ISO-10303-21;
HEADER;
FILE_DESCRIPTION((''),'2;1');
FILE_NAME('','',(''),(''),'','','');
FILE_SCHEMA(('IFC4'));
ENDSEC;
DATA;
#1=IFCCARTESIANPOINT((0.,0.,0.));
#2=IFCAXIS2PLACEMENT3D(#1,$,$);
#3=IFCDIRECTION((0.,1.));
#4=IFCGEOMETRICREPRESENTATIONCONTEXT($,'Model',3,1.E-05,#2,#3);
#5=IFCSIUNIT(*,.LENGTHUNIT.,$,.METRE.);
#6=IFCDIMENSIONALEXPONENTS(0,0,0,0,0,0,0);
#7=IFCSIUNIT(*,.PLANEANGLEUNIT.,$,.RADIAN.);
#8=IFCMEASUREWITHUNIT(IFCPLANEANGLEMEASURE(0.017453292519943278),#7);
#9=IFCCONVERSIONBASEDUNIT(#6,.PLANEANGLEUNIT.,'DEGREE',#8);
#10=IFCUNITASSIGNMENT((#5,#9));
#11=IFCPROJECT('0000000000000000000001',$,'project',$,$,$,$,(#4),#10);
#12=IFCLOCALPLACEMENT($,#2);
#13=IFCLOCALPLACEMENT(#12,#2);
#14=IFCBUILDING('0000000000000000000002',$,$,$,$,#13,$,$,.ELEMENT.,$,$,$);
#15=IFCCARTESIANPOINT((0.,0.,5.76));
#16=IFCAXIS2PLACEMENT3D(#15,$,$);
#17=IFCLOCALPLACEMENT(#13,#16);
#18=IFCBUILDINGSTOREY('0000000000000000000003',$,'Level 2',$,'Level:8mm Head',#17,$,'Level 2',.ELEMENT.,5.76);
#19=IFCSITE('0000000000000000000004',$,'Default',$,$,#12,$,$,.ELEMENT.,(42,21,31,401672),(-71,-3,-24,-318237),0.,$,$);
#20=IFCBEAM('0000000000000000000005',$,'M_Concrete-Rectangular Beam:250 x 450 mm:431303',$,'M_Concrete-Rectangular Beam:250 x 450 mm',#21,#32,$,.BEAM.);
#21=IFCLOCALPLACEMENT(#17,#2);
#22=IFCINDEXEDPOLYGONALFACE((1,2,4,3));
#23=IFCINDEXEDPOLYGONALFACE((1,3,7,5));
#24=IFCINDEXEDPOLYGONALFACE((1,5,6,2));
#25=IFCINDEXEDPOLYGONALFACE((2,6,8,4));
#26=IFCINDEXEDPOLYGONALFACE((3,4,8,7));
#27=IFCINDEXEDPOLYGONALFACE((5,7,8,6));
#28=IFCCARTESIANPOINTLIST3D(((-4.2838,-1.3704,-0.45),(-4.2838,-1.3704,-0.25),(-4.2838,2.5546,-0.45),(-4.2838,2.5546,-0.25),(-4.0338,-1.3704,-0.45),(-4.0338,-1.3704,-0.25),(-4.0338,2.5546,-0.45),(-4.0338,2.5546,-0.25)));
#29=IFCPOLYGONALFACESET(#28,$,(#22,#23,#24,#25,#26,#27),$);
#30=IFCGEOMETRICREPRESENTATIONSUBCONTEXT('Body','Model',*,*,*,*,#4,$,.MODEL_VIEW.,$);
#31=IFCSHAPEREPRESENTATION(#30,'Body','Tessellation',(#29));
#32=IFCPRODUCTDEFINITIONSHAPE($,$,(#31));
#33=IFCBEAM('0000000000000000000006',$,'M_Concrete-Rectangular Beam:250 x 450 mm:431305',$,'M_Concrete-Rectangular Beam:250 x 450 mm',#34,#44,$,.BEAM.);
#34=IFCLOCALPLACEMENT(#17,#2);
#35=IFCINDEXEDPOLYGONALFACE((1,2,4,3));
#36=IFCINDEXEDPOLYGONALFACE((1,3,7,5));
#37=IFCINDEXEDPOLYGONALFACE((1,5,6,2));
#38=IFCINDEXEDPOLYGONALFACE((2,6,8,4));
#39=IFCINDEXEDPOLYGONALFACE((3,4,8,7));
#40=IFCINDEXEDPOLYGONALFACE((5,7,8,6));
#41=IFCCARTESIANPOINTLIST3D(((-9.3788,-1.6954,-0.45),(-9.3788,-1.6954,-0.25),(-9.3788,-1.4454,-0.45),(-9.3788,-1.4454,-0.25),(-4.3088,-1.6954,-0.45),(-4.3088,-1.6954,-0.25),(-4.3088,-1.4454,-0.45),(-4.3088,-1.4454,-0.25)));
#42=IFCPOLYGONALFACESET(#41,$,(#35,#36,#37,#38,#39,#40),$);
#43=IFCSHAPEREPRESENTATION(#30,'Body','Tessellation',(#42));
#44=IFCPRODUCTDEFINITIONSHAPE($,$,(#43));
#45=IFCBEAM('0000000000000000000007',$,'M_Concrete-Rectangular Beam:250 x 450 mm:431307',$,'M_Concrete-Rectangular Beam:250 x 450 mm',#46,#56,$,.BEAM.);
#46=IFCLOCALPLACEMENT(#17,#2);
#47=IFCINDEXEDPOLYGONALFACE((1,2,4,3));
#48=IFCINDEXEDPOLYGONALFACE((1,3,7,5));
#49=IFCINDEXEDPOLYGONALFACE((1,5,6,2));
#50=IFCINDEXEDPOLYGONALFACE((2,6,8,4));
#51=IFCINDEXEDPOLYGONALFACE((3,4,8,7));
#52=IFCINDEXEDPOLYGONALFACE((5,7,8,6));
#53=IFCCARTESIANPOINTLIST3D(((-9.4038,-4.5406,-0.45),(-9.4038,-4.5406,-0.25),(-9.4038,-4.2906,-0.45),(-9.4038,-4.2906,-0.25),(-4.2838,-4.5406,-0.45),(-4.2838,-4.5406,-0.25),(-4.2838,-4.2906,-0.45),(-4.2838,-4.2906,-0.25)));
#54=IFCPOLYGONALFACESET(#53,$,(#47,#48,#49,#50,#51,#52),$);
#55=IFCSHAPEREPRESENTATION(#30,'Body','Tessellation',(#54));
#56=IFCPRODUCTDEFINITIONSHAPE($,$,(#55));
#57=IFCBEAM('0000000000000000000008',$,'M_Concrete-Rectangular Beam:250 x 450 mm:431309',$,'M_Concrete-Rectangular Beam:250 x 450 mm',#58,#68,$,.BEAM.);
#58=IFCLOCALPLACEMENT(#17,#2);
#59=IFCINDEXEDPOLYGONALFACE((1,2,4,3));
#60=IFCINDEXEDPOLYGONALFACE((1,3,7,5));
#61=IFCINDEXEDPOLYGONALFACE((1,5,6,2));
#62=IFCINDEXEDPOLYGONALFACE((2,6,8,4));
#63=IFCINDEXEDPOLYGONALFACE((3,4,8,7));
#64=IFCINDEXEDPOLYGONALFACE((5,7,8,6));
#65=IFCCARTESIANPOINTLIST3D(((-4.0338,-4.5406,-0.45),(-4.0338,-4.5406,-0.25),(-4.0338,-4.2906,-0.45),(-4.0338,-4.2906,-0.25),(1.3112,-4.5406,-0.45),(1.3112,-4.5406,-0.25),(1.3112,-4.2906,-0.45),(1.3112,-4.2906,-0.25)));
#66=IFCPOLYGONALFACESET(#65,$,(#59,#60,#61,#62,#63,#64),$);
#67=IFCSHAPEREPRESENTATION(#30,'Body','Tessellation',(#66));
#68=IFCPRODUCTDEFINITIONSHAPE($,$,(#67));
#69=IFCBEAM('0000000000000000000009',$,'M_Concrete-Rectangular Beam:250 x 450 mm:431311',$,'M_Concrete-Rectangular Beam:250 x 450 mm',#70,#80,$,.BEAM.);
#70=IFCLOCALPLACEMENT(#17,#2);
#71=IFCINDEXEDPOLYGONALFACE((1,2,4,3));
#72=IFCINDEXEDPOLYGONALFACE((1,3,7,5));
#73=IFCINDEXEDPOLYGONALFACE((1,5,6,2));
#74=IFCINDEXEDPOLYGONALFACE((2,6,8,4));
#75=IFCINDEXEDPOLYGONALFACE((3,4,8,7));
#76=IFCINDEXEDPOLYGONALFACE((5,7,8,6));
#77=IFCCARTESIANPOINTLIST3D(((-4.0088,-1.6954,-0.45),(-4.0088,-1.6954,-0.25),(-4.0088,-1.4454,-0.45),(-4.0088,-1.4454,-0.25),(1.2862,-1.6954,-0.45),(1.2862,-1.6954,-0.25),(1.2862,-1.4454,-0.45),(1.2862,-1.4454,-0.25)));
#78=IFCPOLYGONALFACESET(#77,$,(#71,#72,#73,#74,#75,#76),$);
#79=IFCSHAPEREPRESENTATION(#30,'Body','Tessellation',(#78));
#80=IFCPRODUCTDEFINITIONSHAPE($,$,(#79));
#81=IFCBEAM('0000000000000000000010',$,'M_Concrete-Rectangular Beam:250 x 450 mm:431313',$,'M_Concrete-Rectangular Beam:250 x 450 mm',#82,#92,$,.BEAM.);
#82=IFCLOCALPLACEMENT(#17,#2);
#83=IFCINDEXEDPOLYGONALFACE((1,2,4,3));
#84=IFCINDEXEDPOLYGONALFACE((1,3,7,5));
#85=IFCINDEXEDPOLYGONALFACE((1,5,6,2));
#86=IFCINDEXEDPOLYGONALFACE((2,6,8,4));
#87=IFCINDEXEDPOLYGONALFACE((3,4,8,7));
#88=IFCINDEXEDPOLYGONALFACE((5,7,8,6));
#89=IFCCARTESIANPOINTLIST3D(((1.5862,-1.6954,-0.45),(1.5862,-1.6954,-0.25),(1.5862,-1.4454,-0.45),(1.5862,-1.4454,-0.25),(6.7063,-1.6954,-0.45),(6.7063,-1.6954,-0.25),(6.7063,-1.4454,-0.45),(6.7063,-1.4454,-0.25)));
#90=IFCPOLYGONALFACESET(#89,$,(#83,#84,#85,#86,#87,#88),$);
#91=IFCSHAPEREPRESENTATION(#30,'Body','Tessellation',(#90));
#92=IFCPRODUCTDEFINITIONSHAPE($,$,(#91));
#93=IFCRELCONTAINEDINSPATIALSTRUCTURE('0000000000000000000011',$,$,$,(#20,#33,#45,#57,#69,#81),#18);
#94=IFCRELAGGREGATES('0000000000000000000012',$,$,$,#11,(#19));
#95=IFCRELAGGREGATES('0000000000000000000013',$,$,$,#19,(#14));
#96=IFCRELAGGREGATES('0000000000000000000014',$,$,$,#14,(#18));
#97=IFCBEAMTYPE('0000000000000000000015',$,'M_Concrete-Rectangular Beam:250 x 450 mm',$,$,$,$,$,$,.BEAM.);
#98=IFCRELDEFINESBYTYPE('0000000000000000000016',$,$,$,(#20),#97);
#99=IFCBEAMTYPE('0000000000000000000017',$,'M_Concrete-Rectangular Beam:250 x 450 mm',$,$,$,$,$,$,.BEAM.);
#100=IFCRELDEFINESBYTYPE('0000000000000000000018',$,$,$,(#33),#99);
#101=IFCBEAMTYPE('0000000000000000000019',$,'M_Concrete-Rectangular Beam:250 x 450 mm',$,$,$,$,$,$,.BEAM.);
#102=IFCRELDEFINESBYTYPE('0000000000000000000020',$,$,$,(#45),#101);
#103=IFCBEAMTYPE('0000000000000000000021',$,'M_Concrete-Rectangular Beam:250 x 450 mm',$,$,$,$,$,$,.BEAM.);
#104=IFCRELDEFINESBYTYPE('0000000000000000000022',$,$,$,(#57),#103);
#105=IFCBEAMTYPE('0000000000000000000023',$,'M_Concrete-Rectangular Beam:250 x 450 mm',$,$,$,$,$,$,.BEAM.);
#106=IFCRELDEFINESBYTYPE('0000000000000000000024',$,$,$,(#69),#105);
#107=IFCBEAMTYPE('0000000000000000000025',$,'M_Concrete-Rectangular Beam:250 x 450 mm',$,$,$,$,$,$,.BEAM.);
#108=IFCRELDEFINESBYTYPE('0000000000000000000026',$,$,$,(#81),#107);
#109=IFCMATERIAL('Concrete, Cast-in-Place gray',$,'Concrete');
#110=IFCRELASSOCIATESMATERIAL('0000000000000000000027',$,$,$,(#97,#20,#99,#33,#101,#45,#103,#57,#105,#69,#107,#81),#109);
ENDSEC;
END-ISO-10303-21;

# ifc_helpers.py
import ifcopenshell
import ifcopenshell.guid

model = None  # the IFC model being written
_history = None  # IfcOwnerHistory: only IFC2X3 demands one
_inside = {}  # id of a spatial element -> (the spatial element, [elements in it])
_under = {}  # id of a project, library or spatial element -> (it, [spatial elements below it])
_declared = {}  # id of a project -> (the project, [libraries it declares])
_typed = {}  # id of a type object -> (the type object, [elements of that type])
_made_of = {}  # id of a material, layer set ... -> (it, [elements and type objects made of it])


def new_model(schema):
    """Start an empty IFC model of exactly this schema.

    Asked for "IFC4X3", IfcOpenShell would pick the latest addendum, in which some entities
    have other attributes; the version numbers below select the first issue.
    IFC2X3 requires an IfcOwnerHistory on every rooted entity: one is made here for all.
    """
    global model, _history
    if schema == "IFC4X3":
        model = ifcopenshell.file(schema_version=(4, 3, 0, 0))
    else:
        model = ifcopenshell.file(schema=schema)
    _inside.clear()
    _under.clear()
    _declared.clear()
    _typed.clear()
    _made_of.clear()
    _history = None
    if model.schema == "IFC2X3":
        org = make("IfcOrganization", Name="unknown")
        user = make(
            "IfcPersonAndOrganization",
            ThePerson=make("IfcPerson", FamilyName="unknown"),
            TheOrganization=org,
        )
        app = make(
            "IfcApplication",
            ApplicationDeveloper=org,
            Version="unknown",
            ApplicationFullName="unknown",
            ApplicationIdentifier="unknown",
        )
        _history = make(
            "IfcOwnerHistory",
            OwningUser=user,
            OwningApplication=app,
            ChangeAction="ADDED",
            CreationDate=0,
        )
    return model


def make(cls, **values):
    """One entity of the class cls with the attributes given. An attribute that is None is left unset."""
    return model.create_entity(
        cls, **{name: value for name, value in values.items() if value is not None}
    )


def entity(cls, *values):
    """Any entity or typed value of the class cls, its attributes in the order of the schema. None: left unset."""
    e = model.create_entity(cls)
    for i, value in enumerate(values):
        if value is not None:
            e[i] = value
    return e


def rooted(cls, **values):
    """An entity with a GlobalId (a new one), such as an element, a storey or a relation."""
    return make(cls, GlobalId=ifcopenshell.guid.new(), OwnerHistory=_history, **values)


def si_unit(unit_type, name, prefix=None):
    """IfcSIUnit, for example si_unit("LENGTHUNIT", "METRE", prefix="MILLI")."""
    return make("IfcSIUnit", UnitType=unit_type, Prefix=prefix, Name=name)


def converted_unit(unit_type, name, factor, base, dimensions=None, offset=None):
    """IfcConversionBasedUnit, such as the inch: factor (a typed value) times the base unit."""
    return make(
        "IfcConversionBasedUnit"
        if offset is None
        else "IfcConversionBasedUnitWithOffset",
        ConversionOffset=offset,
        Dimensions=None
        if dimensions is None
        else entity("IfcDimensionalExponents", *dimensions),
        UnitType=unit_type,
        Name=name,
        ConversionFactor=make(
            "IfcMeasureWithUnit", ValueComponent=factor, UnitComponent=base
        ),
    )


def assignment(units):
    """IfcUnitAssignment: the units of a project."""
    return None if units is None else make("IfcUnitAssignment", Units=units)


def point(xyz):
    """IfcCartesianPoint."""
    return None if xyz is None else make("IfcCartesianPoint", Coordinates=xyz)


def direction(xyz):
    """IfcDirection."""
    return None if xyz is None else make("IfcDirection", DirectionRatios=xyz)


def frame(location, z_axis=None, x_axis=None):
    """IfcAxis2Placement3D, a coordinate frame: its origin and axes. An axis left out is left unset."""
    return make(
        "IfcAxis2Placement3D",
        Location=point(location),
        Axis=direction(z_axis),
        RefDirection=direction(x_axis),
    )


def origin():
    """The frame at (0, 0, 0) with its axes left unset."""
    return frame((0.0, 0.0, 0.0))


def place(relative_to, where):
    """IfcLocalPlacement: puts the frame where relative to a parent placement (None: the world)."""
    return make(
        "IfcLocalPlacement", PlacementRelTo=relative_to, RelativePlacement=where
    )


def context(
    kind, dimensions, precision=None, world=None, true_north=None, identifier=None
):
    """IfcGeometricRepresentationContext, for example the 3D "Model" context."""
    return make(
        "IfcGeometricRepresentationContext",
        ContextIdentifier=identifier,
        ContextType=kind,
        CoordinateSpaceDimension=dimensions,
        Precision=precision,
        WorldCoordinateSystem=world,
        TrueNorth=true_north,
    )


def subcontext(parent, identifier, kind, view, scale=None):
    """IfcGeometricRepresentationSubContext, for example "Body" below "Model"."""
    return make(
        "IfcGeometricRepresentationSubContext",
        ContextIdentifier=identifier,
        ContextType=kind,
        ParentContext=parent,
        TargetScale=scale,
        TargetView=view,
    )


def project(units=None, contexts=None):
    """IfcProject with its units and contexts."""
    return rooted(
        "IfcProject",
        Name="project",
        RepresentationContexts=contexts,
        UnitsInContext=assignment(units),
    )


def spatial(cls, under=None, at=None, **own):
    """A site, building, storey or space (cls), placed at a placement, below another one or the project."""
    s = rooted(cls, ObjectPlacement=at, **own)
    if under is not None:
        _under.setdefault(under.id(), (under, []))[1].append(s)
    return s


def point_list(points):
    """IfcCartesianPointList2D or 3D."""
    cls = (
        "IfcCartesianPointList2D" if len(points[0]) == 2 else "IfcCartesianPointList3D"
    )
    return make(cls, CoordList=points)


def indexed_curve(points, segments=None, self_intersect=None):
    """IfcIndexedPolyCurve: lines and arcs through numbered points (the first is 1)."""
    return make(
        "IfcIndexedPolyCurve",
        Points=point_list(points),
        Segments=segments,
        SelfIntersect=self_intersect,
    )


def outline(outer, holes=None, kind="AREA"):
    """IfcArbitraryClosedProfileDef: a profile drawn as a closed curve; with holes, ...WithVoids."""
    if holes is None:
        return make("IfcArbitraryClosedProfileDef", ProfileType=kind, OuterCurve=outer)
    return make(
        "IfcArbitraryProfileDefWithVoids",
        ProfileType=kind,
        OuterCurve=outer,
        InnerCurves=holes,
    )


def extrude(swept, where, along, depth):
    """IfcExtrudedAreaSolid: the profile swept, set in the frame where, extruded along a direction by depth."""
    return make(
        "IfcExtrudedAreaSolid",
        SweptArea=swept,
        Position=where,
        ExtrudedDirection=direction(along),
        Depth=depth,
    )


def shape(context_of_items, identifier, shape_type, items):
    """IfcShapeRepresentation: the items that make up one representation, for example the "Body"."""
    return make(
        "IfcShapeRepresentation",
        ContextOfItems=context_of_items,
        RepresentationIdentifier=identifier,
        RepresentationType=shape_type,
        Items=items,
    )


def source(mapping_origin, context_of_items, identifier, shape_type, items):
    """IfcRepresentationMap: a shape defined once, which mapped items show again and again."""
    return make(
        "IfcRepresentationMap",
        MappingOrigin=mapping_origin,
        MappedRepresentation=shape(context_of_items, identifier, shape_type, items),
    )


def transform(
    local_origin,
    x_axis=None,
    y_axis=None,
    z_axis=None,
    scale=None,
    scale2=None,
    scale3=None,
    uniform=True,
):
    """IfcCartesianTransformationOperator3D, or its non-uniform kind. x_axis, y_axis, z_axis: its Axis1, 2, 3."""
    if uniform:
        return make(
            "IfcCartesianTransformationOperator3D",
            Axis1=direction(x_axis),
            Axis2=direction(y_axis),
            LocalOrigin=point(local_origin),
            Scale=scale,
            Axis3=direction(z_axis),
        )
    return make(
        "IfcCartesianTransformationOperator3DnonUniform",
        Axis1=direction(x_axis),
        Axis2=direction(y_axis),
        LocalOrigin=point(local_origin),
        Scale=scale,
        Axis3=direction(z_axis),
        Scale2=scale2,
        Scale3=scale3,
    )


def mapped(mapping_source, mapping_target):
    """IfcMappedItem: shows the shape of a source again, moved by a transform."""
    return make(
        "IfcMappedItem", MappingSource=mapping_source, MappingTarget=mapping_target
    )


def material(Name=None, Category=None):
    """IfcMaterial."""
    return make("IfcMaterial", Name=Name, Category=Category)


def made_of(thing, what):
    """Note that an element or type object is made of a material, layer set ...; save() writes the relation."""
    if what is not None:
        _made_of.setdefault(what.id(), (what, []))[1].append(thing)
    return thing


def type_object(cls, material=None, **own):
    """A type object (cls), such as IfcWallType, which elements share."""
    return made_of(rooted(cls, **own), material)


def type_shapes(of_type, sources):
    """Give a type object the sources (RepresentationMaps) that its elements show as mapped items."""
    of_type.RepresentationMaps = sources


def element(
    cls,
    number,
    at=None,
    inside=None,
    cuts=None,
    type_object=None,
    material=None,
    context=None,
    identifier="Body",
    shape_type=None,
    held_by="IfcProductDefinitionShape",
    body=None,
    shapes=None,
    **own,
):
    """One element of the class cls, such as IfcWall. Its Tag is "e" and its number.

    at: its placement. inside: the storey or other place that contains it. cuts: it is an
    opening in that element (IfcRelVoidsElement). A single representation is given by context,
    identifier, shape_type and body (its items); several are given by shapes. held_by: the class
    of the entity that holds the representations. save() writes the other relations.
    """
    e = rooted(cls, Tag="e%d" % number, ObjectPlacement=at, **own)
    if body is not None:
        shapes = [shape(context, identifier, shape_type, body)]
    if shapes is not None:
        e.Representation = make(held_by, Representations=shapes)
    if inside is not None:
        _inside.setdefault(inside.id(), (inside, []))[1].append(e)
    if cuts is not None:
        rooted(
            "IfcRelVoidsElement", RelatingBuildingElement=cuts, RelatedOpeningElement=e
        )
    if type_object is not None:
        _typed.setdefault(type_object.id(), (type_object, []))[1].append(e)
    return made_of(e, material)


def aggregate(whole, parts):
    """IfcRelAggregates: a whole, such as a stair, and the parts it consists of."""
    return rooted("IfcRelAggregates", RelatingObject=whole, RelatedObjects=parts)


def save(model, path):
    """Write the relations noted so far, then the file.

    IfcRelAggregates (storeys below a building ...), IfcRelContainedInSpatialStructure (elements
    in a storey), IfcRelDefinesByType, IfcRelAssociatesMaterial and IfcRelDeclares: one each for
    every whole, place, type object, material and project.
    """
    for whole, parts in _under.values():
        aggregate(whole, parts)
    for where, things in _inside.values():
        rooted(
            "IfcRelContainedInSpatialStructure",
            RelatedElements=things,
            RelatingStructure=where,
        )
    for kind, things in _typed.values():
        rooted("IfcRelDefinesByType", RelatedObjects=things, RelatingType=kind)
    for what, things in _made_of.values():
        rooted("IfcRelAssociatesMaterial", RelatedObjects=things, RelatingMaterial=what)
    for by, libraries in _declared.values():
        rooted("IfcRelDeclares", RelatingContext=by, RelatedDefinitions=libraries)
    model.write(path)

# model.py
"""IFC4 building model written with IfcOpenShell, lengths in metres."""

from ifc_helpers import new_model, entity, si_unit, converted_unit, direction, frame, origin, place, context, subcontext, project, spatial, indexed_curve, outline, extrude, source, transform, mapped, material, type_object, type_shapes, element, save


model = new_model("IFC4")

# Units and contexts
model_context = context("Model", 3, precision=1e-05, world=origin(), true_north=direction((0.0, 1.0)))
body_context = subcontext(model_context, "Body", "Model", "MODEL_VIEW")
ifc_project = project(units=[si_unit("LENGTHUNIT", "METRE"), converted_unit("PLANEANGLEUNIT", "DEGREE", entity("IfcPlaneAngleMeasure", 0.017453292519943278), si_unit("PLANEANGLEUNIT", "RADIAN"), dimensions=[0, 0, 0, 0, 0, 0, 0])], contexts=[model_context])

# Site, building, storey
site_placement = place(None, origin())
site = spatial("IfcSite", under=ifc_project, at=site_placement, Name="Default", CompositionType="ELEMENT", RefLatitude=(42, 21, 31, 401672), RefLongitude=(-71, -3, -24, -318237), RefElevation=0.0)
building_placement = place(site_placement, origin())
building = spatial("IfcBuilding", under=site, at=building_placement, CompositionType="ELEMENT")
storey_placement = place(building_placement, frame((0.0, 0.0, 5.76)))
storey = spatial("IfcBuildingStorey", under=building, at=storey_placement, Name="Level 2", ObjectType="Level:8mm Head", LongName="Level 2", CompositionType="ELEMENT", Elevation=5.76)

# Beams
ifc_material = material(Name="Concrete, Cast-in-Place gray", Category="Concrete")
beam_type_1 = type_object("IfcBeamType", Name="M_Concrete-Rectangular Beam:250 x 450 mm", PredefinedType="BEAM", material=ifc_material)
shared_shape_1 = source(origin(), body_context, "Body", "SweptSolid", [
    extrude(outline(indexed_curve([(-0.125, -0.1), (0.125, -0.1), (0.125, 0.1), (-0.125, 0.1), (-0.125, -0.1)], self_intersect=False)), frame((-4.1588, 2.5546, 5.41), z_axis=(0.0, -1.0, 0.0), x_axis=(-1.0, 0.0, 0.0)), (0.0, 0.0, 1.0), 3.925),
])
type_shapes(beam_type_1, [shared_shape_1])
beam_1_placement = place(storey_placement, frame((0.0, 0.0, -5.76)))
element("IfcBeam", 1, at=beam_1_placement, inside=storey, type_object=beam_type_1, material=ifc_material, Name="M_Concrete-Rectangular Beam:250 x 450 mm:431303", ObjectType="M_Concrete-Rectangular Beam:250 x 450 mm", PredefinedType="BEAM", context=body_context, shape_type="MappedRepresentation", body=[
    mapped(shared_shape_1, transform((0.0, 0.0, 0.0), scale=1.0)),
])
beam_type_2 = type_object("IfcBeamType", Name="M_Concrete-Rectangular Beam:250 x 450 mm", PredefinedType="BEAM", material=ifc_material)
shared_shape_2 = source(origin(), body_context, "Body", "SweptSolid", [
    extrude(outline(indexed_curve([(-0.1, -0.125), (0.1, -0.125), (0.1, 0.125), (-0.1, 0.125), (-0.1, -0.125)], self_intersect=False)), frame((-9.3788, -1.5704, 5.41), z_axis=(1.0, 0.0, 0.0), x_axis=(0.0, 0.0, -1.0)), (0.0, 0.0, 1.0), 5.07),
])
type_shapes(beam_type_2, [shared_shape_2])
beam_2_placement = place(storey_placement, frame((0.0, 0.0, -5.76)))
element("IfcBeam", 2, at=beam_2_placement, inside=storey, type_object=beam_type_2, material=ifc_material, Name="M_Concrete-Rectangular Beam:250 x 450 mm:431305", ObjectType="M_Concrete-Rectangular Beam:250 x 450 mm", PredefinedType="BEAM", context=body_context, shape_type="MappedRepresentation", body=[
    mapped(shared_shape_2, transform((0.0, 0.0, 0.0), scale=1.0)),
])
beam_type_3 = type_object("IfcBeamType", Name="M_Concrete-Rectangular Beam:250 x 450 mm", PredefinedType="BEAM", material=ifc_material)
shared_shape_3 = source(origin(), body_context, "Body", "SweptSolid", [
    extrude(outline(indexed_curve([(-0.1, -0.125), (0.1, -0.125), (0.1, 0.125), (-0.1, 0.125), (-0.1, -0.125)], self_intersect=False)), frame((-9.4038, -4.4156, 5.41), z_axis=(1.0, 0.0, 0.0), x_axis=(0.0, 0.0, -1.0)), (0.0, 0.0, 1.0), 5.12),
])
type_shapes(beam_type_3, [shared_shape_3])
beam_3_placement = place(storey_placement, frame((0.0, 0.0, -5.76)))
element("IfcBeam", 3, at=beam_3_placement, inside=storey, type_object=beam_type_3, material=ifc_material, Name="M_Concrete-Rectangular Beam:250 x 450 mm:431307", ObjectType="M_Concrete-Rectangular Beam:250 x 450 mm", PredefinedType="BEAM", context=body_context, shape_type="MappedRepresentation", body=[
    mapped(shared_shape_3, transform((0.0, 0.0, 0.0), scale=1.0)),
])
beam_type_4 = type_object("IfcBeamType", Name="M_Concrete-Rectangular Beam:250 x 450 mm", PredefinedType="BEAM", material=ifc_material)
shared_shape_4 = source(origin(), body_context, "Body", "SweptSolid", [
    extrude(outline(indexed_curve([(-0.1, -0.125), (0.1, -0.125), (0.1, 0.125), (-0.1, 0.125), (-0.1, -0.125)], self_intersect=False)), frame((-4.0338, -4.4156, 5.41), z_axis=(1.0, 0.0, 0.0), x_axis=(0.0, 0.0, -1.0)), (0.0, 0.0, 1.0), 5.345),
])
type_shapes(beam_type_4, [shared_shape_4])
beam_4_placement = place(storey_placement, frame((0.0, 0.0, -5.76)))
element("IfcBeam", 4, at=beam_4_placement, inside=storey, type_object=beam_type_4, material=ifc_material, Name="M_Concrete-Rectangular Beam:250 x 450 mm:431309", ObjectType="M_Concrete-Rectangular Beam:250 x 450 mm", PredefinedType="BEAM", context=body_context, shape_type="MappedRepresentation", body=[
    mapped(shared_shape_4, transform((0.0, 0.0, 0.0), scale=1.0)),
])
beam_type_5 = type_object("IfcBeamType", Name="M_Concrete-Rectangular Beam:250 x 450 mm", PredefinedType="BEAM", material=ifc_material)
shared_shape_5 = source(origin(), body_context, "Body", "SweptSolid", [
    extrude(outline(indexed_curve([(-0.1, -0.125), (0.1, -0.125), (0.1, 0.125), (-0.1, 0.125), (-0.1, -0.125)], self_intersect=False)), frame((-4.0088, -1.5704, 5.41), z_axis=(1.0, 0.0, 0.0), x_axis=(0.0, 0.0, -1.0)), (0.0, 0.0, 1.0), 5.295),
])
type_shapes(beam_type_5, [shared_shape_5])
beam_5_placement = place(storey_placement, frame((0.0, 0.0, -5.76)))
element("IfcBeam", 5, at=beam_5_placement, inside=storey, type_object=beam_type_5, material=ifc_material, Name="M_Concrete-Rectangular Beam:250 x 450 mm:431311", ObjectType="M_Concrete-Rectangular Beam:250 x 450 mm", PredefinedType="BEAM", context=body_context, shape_type="MappedRepresentation", body=[
    mapped(shared_shape_5, transform((0.0, 0.0, 0.0), scale=1.0)),
])
beam_type_6 = type_object("IfcBeamType", Name="M_Concrete-Rectangular Beam:250 x 450 mm", PredefinedType="BEAM", material=ifc_material)
shared_shape_6 = source(origin(), body_context, "Body", "SweptSolid", [
    extrude(outline(indexed_curve([(-0.1, -0.125), (0.1, -0.125), (0.1, 0.125), (-0.1, 0.125), (-0.1, -0.125)], self_intersect=False)), frame((1.5862, -1.5704, 5.41), z_axis=(1.0, 0.0, 0.0), x_axis=(0.0, 0.0, -1.0)), (0.0, 0.0, 1.0), 5.1201),
])
type_shapes(beam_type_6, [shared_shape_6])
beam_6_placement = place(storey_placement, frame((0.0, 0.0, -5.76)))
element("IfcBeam", 6, at=beam_6_placement, inside=storey, type_object=beam_type_6, material=ifc_material, Name="M_Concrete-Rectangular Beam:250 x 450 mm:431313", ObjectType="M_Concrete-Rectangular Beam:250 x 450 mm", PredefinedType="BEAM", context=body_context, shape_type="MappedRepresentation", body=[
    mapped(shared_shape_6, transform((0.0, 0.0, 0.0), scale=1.0)),
])

save(model, "model.ifc")
